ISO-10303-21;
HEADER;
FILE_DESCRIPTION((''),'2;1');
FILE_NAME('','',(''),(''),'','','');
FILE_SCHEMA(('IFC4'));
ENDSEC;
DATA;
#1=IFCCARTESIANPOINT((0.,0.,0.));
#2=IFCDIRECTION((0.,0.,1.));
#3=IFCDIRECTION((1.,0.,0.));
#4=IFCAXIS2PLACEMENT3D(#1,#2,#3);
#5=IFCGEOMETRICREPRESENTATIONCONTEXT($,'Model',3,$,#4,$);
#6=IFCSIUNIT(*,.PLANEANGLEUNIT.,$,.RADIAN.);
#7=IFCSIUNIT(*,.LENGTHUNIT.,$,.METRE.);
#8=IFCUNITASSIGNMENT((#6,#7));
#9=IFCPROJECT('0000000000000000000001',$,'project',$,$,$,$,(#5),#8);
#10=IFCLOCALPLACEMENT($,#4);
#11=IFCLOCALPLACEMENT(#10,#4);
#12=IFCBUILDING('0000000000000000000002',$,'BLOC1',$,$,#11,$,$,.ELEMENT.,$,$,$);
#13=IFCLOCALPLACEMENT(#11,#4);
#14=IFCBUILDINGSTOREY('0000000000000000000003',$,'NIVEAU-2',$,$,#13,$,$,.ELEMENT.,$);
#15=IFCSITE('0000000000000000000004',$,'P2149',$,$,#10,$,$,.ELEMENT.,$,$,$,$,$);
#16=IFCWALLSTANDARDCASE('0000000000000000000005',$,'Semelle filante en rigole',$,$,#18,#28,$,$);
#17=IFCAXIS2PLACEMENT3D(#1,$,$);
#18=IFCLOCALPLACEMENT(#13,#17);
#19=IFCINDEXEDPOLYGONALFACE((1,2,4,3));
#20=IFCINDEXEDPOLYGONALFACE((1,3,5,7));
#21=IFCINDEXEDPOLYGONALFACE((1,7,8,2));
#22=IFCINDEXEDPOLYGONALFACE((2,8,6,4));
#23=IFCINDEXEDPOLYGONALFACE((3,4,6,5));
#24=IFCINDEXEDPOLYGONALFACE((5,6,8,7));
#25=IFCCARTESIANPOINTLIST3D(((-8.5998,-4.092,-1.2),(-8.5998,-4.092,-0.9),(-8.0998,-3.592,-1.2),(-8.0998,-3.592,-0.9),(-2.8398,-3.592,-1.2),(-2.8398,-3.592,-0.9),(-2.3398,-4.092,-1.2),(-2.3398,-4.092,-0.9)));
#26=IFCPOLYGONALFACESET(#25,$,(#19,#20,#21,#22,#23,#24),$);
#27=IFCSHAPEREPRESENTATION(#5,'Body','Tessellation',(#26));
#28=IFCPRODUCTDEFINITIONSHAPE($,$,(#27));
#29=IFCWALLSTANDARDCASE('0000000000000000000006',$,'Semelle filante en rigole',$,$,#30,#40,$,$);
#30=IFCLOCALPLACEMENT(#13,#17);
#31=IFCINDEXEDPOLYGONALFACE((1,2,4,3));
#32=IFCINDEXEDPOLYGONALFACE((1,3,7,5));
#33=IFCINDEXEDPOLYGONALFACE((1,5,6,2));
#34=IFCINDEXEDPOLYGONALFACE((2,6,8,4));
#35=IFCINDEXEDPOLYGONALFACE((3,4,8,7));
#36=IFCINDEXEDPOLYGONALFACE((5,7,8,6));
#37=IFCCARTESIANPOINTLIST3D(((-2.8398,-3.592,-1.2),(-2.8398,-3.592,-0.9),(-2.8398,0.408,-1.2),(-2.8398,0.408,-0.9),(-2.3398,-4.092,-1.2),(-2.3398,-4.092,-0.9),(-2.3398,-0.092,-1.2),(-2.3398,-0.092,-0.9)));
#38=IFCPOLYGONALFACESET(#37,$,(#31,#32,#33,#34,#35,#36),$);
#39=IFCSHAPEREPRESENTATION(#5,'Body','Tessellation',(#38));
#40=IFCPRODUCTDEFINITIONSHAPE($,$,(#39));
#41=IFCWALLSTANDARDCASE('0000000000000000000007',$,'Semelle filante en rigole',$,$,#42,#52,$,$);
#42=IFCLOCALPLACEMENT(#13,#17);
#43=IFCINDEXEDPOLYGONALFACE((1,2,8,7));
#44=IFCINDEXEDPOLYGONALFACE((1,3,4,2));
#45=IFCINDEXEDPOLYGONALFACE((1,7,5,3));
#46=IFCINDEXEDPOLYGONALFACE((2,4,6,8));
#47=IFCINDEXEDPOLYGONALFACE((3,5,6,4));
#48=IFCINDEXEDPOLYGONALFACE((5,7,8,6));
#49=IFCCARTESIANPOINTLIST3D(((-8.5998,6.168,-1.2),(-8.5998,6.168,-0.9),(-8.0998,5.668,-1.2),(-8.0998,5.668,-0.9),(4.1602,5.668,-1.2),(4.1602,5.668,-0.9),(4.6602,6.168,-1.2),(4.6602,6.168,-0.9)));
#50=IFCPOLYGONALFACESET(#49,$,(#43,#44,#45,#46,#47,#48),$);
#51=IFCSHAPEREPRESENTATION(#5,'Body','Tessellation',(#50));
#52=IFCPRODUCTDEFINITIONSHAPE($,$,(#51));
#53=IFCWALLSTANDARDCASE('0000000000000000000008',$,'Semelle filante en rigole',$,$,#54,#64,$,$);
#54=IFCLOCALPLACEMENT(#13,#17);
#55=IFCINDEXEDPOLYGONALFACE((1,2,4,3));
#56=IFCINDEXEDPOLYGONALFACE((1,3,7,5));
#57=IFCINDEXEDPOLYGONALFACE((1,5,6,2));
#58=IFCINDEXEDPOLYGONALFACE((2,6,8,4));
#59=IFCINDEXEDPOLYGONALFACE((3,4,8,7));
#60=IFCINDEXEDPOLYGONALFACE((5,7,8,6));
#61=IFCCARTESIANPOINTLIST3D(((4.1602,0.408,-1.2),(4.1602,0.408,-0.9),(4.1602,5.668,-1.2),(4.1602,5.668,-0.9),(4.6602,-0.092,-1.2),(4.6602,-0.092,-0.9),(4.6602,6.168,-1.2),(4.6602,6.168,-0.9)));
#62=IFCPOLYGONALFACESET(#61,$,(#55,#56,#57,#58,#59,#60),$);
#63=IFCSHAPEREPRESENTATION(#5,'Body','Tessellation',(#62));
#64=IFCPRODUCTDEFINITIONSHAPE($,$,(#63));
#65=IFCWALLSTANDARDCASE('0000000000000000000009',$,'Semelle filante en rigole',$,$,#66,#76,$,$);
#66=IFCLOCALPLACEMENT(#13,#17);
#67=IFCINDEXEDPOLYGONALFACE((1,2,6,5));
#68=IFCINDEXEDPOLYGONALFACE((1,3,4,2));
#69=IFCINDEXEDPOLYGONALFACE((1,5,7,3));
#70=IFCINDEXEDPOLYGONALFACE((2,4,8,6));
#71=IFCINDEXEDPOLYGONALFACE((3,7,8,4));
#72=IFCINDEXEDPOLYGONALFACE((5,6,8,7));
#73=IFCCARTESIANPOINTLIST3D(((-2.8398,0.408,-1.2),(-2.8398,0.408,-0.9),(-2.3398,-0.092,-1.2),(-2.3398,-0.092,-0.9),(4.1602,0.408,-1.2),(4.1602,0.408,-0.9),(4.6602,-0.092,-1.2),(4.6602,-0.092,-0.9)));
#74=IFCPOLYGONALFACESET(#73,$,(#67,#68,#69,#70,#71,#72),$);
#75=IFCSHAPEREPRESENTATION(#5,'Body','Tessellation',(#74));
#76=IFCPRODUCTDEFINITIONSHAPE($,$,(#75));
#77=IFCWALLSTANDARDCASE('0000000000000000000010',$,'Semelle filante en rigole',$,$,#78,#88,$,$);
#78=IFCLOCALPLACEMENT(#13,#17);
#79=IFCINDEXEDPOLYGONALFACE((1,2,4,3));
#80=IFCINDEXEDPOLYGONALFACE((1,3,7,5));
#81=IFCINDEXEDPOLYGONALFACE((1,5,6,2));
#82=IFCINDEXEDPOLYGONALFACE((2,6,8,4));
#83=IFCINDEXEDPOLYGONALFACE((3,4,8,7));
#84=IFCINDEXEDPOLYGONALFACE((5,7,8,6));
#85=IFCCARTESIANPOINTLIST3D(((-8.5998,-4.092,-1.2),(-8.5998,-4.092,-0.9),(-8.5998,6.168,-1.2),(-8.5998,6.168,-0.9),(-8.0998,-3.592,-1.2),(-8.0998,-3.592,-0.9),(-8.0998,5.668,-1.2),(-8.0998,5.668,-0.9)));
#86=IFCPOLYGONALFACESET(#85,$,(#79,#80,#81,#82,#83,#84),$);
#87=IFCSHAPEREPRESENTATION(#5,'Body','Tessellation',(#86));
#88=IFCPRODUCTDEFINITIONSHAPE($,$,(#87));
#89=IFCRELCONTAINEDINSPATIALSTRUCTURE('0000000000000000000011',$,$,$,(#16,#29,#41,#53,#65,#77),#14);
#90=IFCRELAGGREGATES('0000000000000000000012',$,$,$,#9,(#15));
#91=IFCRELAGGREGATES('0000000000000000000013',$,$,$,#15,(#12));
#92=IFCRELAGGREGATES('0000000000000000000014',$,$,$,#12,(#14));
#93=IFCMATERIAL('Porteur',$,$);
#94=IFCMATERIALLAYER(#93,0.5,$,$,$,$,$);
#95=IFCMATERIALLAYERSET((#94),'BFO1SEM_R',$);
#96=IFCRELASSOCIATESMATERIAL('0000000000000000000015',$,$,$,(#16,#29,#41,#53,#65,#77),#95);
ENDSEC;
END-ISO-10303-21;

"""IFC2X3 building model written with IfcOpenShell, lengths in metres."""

from ifc_helpers import new_model, si_unit, point, frame, origin_with_axes, place, context, project, spatial, line_curve, trimmed, segment, composite_curve, outline, extrude, material, layer, layer_set, layer_usage, element, save


model = new_model("IFC2X3")

# Units and contexts
model_context = context("Model", 3, world=origin_with_axes())
ifc_project = project(units=[si_unit("PLANEANGLEUNIT", "RADIAN"), si_unit("LENGTHUNIT", "METRE")], contexts=[model_context])

# Site, building, storey
site_placement = place(None, origin_with_axes())
site = spatial("IfcSite", under=ifc_project, at=site_placement, Name="P2149", CompositionType="ELEMENT")
building_placement = place(site_placement, origin_with_axes())
building = spatial("IfcBuilding", under=site, at=building_placement, Name="BLOC1", CompositionType="ELEMENT")
storey_placement = place(building_placement, origin_with_axes())
storey = spatial("IfcBuildingStorey", under=building, at=storey_placement, Name="NIVEAU-2", CompositionType="ELEMENT")

# Walls
ifc_material = material(Name="Porteur")
ifc_layer = layer(ifc_material, 0.5)
ifc_layer_set = layer_set([ifc_layer], Name="BFO1SEM_R")
ifc_layer_usage = layer_usage(ifc_layer_set, "AXIS2", "POSITIVE", 0.0)
wall_1_placement = place(storey_placement, frame((-2.8398, -3.592, -1.2), z_axis=(0.0, 0.0, 1.0), x_axis=(-1.0, 0.0, 0.0)))
element("IfcWallStandardCase", 1, at=wall_1_placement, inside=storey, material=ifc_layer_usage, Name="Semelle filante en rigole", context=model_context, shape_type="SweptSolid", body=[
    extrude(outline(composite_curve([segment(trimmed(line_curve((0.0, 0.0), (1.0, 0.0), 5.26), [point((0.0, 0.0))], [point((5.26, 0.0))], True, "CARTESIAN"), True, "CONTINUOUS"), segment(trimmed(line_curve((5.26, 0.0), (0.707107, 0.707107), 0.707107), [point((5.26, 0.0))], [point((5.76, 0.5))], True, "CARTESIAN"), True, "CONTINUOUS"), segment(trimmed(line_curve((5.76, 0.5), (-1.0, 0.0), 6.26), [point((5.76, 0.5))], [point((-0.5, 0.5))], True, "CARTESIAN"), True, "CONTINUOUS"), segment(trimmed(line_curve((-0.5, 0.5), (0.707107, -0.707107), 0.707107), [point((-0.5, 0.5))], [point((0.0, 0.0))], True, "CARTESIAN"), True, "CONTINUOUS")], self_intersect=False)), origin_with_axes(), (0.0, 0.0, 1.0), 0.3),
])
wall_2_placement = place(storey_placement, frame((-2.8398, 0.408, -1.2), z_axis=(0.0, 0.0, 1.0), x_axis=(0.0, -1.0, 0.0)))
element("IfcWallStandardCase", 2, at=wall_2_placement, inside=storey, material=ifc_layer_usage, Name="Semelle filante en rigole", context=model_context, shape_type="SweptSolid", body=[
    extrude(outline(composite_curve([segment(trimmed(line_curve((0.0, 0.0), (1.0, 0.0), 4.0), [point((0.0, 0.0))], [point((4.0, 0.0))], True, "CARTESIAN"), True, "CONTINUOUS"), segment(trimmed(line_curve((4.0, 0.0), (0.707107, 0.707107), 0.707107), [point((4.0, 0.0))], [point((4.5, 0.5))], True, "CARTESIAN"), True, "CONTINUOUS"), segment(trimmed(line_curve((4.5, 0.5), (-1.0, 0.0), 4.0), [point((4.5, 0.5))], [point((0.5, 0.5))], True, "CARTESIAN"), True, "CONTINUOUS"), segment(trimmed(line_curve((0.5, 0.5), (-0.707107, -0.707107), 0.707107), [point((0.5, 0.5))], [point((0.0, 0.0))], True, "CARTESIAN"), True, "CONTINUOUS")], self_intersect=False)), origin_with_axes(), (0.0, 0.0, 1.0), 0.3),
])
wall_3_placement = place(storey_placement, frame((-8.0998, 5.668, -1.2), z_axis=(0.0, 0.0, 1.0), x_axis=(1.0, 0.0, 0.0)))
element("IfcWallStandardCase", 3, at=wall_3_placement, inside=storey, material=ifc_layer_usage, Name="Semelle filante en rigole", context=model_context, shape_type="SweptSolid", body=[
    extrude(outline(composite_curve([segment(trimmed(line_curve((0.0, 0.0), (1.0, 0.0), 12.26), [point((0.0, 0.0))], [point((12.26, 0.0))], True, "CARTESIAN"), True, "CONTINUOUS"), segment(trimmed(line_curve((12.26, 0.0), (0.707107, 0.707107), 0.707107), [point((12.26, 0.0))], [point((12.76, 0.5))], True, "CARTESIAN"), True, "CONTINUOUS"), segment(trimmed(line_curve((12.76, 0.5), (-1.0, 0.0), 13.26), [point((12.76, 0.5))], [point((-0.5, 0.5))], True, "CARTESIAN"), True, "CONTINUOUS"), segment(trimmed(line_curve((-0.5, 0.5), (0.707107, -0.707107), 0.707107), [point((-0.5, 0.5))], [point((0.0, 0.0))], True, "CARTESIAN"), True, "CONTINUOUS")], self_intersect=False)), origin_with_axes(), (0.0, 0.0, 1.0), 0.3),
])
wall_4_placement = place(storey_placement, frame((4.1602, 5.668, -1.2), z_axis=(0.0, 0.0, 1.0), x_axis=(0.0, -1.0, 0.0)))
element("IfcWallStandardCase", 4, at=wall_4_placement, inside=storey, material=ifc_layer_usage, Name="Semelle filante en rigole", context=model_context, shape_type="SweptSolid", body=[
    extrude(outline(composite_curve([segment(trimmed(line_curve((0.0, 0.0), (1.0, 0.0), 5.26), [point((0.0, 0.0))], [point((5.26, 0.0))], True, "CARTESIAN"), True, "CONTINUOUS"), segment(trimmed(line_curve((5.26, 0.0), (0.707107, 0.707107), 0.707107), [point((5.26, 0.0))], [point((5.76, 0.5))], True, "CARTESIAN"), True, "CONTINUOUS"), segment(trimmed(line_curve((5.76, 0.5), (-1.0, 0.0), 6.26), [point((5.76, 0.5))], [point((-0.5, 0.5))], True, "CARTESIAN"), True, "CONTINUOUS"), segment(trimmed(line_curve((-0.5, 0.5), (0.707107, -0.707107), 0.707107), [point((-0.5, 0.5))], [point((0.0, 0.0))], True, "CARTESIAN"), True, "CONTINUOUS")], self_intersect=False)), origin_with_axes(), (0.0, 0.0, 1.0), 0.3),
])
wall_5_placement = place(storey_placement, frame((4.1602, 0.408, -1.2), z_axis=(0.0, 0.0, 1.0), x_axis=(-1.0, 0.0, 0.0)))
element("IfcWallStandardCase", 5, at=wall_5_placement, inside=storey, material=ifc_layer_usage, Name="Semelle filante en rigole", context=model_context, shape_type="SweptSolid", body=[
    extrude(outline(composite_curve([segment(trimmed(line_curve((0.0, 0.0), (1.0, 0.0), 7.0), [point((0.0, 0.0))], [point((7.0, 0.0))], True, "CARTESIAN"), True, "CONTINUOUS"), segment(trimmed(line_curve((7.0, 0.0), (-0.707107, 0.707107), 0.707107), [point((7.0, 0.0))], [point((6.5, 0.5))], True, "CARTESIAN"), True, "CONTINUOUS"), segment(trimmed(line_curve((6.5, 0.5), (-1.0, 0.0), 7.0), [point((6.5, 0.5))], [point((-0.5, 0.5))], True, "CARTESIAN"), True, "CONTINUOUS"), segment(trimmed(line_curve((-0.5, 0.5), (0.707107, -0.707107), 0.707107), [point((-0.5, 0.5))], [point((0.0, 0.0))], True, "CARTESIAN"), True, "CONTINUOUS")], self_intersect=False)), origin_with_axes(), (0.0, 0.0, 1.0), 0.3),
])
wall_6_placement = place(storey_placement, frame((-8.0998, -3.592, -1.2), z_axis=(0.0, 0.0, 1.0), x_axis=(0.0, 1.0, 0.0)))
element("IfcWallStandardCase", 6, at=wall_6_placement, inside=storey, material=ifc_layer_usage, Name="Semelle filante en rigole", context=model_context, shape_type="SweptSolid", body=[
    extrude(outline(composite_curve([segment(trimmed(line_curve((0.0, 0.0), (1.0, 0.0), 9.26), [point((0.0, 0.0))], [point((9.26, 0.0))], True, "CARTESIAN"), True, "CONTINUOUS"), segment(trimmed(line_curve((9.26, 0.0), (0.707107, 0.707107), 0.707107), [point((9.26, 0.0))], [point((9.76, 0.5))], True, "CARTESIAN"), True, "CONTINUOUS"), segment(trimmed(line_curve((9.76, 0.5), (-1.0, 0.0), 10.26), [point((9.76, 0.5))], [point((-0.5, 0.5))], True, "CARTESIAN"), True, "CONTINUOUS"), segment(trimmed(line_curve((-0.5, 0.5), (0.707107, -0.707107), 0.707107), [point((-0.5, 0.5))], [point((0.0, 0.0))], True, "CARTESIAN"), True, "CONTINUOUS")], self_intersect=False)), origin_with_axes(), (0.0, 0.0, 1.0), 0.3),
])

save(model, "model.ifc")
